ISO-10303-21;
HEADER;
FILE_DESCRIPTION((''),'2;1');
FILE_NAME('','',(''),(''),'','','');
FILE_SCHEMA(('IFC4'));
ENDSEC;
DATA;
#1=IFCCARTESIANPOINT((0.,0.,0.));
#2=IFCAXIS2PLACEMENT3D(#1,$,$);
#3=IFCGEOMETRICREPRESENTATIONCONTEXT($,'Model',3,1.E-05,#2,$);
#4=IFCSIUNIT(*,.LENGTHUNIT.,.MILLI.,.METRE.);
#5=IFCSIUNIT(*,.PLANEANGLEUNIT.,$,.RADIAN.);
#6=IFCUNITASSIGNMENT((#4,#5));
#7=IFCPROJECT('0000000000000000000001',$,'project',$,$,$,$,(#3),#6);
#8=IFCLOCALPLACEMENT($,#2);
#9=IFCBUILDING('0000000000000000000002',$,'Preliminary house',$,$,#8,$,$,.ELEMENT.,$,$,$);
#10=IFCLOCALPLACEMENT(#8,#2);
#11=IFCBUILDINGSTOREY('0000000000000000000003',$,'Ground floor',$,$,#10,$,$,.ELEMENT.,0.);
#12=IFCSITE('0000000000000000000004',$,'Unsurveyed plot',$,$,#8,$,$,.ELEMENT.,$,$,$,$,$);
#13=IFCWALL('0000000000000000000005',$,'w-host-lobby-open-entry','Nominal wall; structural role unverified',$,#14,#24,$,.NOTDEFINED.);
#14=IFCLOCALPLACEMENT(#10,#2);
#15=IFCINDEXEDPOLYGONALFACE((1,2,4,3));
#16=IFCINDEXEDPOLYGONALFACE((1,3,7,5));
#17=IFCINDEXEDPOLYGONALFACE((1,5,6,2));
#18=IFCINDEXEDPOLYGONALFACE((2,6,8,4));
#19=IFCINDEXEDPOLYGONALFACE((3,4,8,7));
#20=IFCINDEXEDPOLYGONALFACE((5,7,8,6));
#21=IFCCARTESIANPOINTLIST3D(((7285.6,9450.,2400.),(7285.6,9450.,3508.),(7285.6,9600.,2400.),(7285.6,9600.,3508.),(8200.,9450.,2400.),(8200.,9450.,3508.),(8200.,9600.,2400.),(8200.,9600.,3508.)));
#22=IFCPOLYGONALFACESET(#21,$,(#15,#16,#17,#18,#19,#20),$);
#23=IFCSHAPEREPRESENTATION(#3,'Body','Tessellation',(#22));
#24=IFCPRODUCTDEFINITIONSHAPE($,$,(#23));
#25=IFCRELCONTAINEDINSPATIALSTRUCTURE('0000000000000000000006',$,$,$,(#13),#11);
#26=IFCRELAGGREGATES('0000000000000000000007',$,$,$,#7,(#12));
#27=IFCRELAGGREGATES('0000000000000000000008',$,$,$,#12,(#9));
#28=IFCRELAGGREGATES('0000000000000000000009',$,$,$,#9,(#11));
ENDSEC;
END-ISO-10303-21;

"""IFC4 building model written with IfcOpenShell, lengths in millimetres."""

from ifc_helpers import new_model, si_unit, origin, place, context, project, spatial, polyline, outline, extrude, element, save


model = new_model("IFC4")

# Units and contexts
model_context = context("Model", 3, precision=1e-05, world=origin())
ifc_project = project(units=[si_unit("LENGTHUNIT", "METRE", prefix="MILLI"), si_unit("PLANEANGLEUNIT", "RADIAN")], contexts=[model_context])

# Site, building, storey
placement_1 = place(None, origin())
site = spatial("IfcSite", under=ifc_project, at=placement_1, Name="Unsurveyed plot", CompositionType="ELEMENT")
building = spatial("IfcBuilding", under=site, at=placement_1, Name="Preliminary house", CompositionType="ELEMENT")
placement_2 = place(placement_1, origin())
storey = spatial("IfcBuildingStorey", under=building, at=placement_2, Name="Ground floor", CompositionType="ELEMENT", Elevation=0.0)

# Wall, opening
wall_1 = element("IfcWall", 1, at=placement_2, inside=storey, Name="w-host-lobby-open-entry", Description="Nominal wall; structural role unverified", PredefinedType="NOTDEFINED", context=model_context, shape_type="SweptSolid", body=[
    extrude(outline(polyline([(7285.6, 9450.0), (8200.0, 9450.0), (8200.0, 9600.0), (7285.6, 9600.0), (7285.6, 9450.0)])), origin(), (0.0, 0.0, 1.0), 3508.0),
])
element("IfcOpeningElement", 2, at=placement_2, cuts=wall_1, PredefinedType="OPENING", context=model_context, shape_type="SweptSolid", body=[
    extrude(outline(polyline([(7285.6, 9075.0), (8200.0, 9075.0), (8200.0, 9975.0), (7285.6, 9975.0), (7285.6, 9075.0)])), origin(), (0.0, 0.0, 1.0), 2400.0),
])

save(model, "model.ifc")
